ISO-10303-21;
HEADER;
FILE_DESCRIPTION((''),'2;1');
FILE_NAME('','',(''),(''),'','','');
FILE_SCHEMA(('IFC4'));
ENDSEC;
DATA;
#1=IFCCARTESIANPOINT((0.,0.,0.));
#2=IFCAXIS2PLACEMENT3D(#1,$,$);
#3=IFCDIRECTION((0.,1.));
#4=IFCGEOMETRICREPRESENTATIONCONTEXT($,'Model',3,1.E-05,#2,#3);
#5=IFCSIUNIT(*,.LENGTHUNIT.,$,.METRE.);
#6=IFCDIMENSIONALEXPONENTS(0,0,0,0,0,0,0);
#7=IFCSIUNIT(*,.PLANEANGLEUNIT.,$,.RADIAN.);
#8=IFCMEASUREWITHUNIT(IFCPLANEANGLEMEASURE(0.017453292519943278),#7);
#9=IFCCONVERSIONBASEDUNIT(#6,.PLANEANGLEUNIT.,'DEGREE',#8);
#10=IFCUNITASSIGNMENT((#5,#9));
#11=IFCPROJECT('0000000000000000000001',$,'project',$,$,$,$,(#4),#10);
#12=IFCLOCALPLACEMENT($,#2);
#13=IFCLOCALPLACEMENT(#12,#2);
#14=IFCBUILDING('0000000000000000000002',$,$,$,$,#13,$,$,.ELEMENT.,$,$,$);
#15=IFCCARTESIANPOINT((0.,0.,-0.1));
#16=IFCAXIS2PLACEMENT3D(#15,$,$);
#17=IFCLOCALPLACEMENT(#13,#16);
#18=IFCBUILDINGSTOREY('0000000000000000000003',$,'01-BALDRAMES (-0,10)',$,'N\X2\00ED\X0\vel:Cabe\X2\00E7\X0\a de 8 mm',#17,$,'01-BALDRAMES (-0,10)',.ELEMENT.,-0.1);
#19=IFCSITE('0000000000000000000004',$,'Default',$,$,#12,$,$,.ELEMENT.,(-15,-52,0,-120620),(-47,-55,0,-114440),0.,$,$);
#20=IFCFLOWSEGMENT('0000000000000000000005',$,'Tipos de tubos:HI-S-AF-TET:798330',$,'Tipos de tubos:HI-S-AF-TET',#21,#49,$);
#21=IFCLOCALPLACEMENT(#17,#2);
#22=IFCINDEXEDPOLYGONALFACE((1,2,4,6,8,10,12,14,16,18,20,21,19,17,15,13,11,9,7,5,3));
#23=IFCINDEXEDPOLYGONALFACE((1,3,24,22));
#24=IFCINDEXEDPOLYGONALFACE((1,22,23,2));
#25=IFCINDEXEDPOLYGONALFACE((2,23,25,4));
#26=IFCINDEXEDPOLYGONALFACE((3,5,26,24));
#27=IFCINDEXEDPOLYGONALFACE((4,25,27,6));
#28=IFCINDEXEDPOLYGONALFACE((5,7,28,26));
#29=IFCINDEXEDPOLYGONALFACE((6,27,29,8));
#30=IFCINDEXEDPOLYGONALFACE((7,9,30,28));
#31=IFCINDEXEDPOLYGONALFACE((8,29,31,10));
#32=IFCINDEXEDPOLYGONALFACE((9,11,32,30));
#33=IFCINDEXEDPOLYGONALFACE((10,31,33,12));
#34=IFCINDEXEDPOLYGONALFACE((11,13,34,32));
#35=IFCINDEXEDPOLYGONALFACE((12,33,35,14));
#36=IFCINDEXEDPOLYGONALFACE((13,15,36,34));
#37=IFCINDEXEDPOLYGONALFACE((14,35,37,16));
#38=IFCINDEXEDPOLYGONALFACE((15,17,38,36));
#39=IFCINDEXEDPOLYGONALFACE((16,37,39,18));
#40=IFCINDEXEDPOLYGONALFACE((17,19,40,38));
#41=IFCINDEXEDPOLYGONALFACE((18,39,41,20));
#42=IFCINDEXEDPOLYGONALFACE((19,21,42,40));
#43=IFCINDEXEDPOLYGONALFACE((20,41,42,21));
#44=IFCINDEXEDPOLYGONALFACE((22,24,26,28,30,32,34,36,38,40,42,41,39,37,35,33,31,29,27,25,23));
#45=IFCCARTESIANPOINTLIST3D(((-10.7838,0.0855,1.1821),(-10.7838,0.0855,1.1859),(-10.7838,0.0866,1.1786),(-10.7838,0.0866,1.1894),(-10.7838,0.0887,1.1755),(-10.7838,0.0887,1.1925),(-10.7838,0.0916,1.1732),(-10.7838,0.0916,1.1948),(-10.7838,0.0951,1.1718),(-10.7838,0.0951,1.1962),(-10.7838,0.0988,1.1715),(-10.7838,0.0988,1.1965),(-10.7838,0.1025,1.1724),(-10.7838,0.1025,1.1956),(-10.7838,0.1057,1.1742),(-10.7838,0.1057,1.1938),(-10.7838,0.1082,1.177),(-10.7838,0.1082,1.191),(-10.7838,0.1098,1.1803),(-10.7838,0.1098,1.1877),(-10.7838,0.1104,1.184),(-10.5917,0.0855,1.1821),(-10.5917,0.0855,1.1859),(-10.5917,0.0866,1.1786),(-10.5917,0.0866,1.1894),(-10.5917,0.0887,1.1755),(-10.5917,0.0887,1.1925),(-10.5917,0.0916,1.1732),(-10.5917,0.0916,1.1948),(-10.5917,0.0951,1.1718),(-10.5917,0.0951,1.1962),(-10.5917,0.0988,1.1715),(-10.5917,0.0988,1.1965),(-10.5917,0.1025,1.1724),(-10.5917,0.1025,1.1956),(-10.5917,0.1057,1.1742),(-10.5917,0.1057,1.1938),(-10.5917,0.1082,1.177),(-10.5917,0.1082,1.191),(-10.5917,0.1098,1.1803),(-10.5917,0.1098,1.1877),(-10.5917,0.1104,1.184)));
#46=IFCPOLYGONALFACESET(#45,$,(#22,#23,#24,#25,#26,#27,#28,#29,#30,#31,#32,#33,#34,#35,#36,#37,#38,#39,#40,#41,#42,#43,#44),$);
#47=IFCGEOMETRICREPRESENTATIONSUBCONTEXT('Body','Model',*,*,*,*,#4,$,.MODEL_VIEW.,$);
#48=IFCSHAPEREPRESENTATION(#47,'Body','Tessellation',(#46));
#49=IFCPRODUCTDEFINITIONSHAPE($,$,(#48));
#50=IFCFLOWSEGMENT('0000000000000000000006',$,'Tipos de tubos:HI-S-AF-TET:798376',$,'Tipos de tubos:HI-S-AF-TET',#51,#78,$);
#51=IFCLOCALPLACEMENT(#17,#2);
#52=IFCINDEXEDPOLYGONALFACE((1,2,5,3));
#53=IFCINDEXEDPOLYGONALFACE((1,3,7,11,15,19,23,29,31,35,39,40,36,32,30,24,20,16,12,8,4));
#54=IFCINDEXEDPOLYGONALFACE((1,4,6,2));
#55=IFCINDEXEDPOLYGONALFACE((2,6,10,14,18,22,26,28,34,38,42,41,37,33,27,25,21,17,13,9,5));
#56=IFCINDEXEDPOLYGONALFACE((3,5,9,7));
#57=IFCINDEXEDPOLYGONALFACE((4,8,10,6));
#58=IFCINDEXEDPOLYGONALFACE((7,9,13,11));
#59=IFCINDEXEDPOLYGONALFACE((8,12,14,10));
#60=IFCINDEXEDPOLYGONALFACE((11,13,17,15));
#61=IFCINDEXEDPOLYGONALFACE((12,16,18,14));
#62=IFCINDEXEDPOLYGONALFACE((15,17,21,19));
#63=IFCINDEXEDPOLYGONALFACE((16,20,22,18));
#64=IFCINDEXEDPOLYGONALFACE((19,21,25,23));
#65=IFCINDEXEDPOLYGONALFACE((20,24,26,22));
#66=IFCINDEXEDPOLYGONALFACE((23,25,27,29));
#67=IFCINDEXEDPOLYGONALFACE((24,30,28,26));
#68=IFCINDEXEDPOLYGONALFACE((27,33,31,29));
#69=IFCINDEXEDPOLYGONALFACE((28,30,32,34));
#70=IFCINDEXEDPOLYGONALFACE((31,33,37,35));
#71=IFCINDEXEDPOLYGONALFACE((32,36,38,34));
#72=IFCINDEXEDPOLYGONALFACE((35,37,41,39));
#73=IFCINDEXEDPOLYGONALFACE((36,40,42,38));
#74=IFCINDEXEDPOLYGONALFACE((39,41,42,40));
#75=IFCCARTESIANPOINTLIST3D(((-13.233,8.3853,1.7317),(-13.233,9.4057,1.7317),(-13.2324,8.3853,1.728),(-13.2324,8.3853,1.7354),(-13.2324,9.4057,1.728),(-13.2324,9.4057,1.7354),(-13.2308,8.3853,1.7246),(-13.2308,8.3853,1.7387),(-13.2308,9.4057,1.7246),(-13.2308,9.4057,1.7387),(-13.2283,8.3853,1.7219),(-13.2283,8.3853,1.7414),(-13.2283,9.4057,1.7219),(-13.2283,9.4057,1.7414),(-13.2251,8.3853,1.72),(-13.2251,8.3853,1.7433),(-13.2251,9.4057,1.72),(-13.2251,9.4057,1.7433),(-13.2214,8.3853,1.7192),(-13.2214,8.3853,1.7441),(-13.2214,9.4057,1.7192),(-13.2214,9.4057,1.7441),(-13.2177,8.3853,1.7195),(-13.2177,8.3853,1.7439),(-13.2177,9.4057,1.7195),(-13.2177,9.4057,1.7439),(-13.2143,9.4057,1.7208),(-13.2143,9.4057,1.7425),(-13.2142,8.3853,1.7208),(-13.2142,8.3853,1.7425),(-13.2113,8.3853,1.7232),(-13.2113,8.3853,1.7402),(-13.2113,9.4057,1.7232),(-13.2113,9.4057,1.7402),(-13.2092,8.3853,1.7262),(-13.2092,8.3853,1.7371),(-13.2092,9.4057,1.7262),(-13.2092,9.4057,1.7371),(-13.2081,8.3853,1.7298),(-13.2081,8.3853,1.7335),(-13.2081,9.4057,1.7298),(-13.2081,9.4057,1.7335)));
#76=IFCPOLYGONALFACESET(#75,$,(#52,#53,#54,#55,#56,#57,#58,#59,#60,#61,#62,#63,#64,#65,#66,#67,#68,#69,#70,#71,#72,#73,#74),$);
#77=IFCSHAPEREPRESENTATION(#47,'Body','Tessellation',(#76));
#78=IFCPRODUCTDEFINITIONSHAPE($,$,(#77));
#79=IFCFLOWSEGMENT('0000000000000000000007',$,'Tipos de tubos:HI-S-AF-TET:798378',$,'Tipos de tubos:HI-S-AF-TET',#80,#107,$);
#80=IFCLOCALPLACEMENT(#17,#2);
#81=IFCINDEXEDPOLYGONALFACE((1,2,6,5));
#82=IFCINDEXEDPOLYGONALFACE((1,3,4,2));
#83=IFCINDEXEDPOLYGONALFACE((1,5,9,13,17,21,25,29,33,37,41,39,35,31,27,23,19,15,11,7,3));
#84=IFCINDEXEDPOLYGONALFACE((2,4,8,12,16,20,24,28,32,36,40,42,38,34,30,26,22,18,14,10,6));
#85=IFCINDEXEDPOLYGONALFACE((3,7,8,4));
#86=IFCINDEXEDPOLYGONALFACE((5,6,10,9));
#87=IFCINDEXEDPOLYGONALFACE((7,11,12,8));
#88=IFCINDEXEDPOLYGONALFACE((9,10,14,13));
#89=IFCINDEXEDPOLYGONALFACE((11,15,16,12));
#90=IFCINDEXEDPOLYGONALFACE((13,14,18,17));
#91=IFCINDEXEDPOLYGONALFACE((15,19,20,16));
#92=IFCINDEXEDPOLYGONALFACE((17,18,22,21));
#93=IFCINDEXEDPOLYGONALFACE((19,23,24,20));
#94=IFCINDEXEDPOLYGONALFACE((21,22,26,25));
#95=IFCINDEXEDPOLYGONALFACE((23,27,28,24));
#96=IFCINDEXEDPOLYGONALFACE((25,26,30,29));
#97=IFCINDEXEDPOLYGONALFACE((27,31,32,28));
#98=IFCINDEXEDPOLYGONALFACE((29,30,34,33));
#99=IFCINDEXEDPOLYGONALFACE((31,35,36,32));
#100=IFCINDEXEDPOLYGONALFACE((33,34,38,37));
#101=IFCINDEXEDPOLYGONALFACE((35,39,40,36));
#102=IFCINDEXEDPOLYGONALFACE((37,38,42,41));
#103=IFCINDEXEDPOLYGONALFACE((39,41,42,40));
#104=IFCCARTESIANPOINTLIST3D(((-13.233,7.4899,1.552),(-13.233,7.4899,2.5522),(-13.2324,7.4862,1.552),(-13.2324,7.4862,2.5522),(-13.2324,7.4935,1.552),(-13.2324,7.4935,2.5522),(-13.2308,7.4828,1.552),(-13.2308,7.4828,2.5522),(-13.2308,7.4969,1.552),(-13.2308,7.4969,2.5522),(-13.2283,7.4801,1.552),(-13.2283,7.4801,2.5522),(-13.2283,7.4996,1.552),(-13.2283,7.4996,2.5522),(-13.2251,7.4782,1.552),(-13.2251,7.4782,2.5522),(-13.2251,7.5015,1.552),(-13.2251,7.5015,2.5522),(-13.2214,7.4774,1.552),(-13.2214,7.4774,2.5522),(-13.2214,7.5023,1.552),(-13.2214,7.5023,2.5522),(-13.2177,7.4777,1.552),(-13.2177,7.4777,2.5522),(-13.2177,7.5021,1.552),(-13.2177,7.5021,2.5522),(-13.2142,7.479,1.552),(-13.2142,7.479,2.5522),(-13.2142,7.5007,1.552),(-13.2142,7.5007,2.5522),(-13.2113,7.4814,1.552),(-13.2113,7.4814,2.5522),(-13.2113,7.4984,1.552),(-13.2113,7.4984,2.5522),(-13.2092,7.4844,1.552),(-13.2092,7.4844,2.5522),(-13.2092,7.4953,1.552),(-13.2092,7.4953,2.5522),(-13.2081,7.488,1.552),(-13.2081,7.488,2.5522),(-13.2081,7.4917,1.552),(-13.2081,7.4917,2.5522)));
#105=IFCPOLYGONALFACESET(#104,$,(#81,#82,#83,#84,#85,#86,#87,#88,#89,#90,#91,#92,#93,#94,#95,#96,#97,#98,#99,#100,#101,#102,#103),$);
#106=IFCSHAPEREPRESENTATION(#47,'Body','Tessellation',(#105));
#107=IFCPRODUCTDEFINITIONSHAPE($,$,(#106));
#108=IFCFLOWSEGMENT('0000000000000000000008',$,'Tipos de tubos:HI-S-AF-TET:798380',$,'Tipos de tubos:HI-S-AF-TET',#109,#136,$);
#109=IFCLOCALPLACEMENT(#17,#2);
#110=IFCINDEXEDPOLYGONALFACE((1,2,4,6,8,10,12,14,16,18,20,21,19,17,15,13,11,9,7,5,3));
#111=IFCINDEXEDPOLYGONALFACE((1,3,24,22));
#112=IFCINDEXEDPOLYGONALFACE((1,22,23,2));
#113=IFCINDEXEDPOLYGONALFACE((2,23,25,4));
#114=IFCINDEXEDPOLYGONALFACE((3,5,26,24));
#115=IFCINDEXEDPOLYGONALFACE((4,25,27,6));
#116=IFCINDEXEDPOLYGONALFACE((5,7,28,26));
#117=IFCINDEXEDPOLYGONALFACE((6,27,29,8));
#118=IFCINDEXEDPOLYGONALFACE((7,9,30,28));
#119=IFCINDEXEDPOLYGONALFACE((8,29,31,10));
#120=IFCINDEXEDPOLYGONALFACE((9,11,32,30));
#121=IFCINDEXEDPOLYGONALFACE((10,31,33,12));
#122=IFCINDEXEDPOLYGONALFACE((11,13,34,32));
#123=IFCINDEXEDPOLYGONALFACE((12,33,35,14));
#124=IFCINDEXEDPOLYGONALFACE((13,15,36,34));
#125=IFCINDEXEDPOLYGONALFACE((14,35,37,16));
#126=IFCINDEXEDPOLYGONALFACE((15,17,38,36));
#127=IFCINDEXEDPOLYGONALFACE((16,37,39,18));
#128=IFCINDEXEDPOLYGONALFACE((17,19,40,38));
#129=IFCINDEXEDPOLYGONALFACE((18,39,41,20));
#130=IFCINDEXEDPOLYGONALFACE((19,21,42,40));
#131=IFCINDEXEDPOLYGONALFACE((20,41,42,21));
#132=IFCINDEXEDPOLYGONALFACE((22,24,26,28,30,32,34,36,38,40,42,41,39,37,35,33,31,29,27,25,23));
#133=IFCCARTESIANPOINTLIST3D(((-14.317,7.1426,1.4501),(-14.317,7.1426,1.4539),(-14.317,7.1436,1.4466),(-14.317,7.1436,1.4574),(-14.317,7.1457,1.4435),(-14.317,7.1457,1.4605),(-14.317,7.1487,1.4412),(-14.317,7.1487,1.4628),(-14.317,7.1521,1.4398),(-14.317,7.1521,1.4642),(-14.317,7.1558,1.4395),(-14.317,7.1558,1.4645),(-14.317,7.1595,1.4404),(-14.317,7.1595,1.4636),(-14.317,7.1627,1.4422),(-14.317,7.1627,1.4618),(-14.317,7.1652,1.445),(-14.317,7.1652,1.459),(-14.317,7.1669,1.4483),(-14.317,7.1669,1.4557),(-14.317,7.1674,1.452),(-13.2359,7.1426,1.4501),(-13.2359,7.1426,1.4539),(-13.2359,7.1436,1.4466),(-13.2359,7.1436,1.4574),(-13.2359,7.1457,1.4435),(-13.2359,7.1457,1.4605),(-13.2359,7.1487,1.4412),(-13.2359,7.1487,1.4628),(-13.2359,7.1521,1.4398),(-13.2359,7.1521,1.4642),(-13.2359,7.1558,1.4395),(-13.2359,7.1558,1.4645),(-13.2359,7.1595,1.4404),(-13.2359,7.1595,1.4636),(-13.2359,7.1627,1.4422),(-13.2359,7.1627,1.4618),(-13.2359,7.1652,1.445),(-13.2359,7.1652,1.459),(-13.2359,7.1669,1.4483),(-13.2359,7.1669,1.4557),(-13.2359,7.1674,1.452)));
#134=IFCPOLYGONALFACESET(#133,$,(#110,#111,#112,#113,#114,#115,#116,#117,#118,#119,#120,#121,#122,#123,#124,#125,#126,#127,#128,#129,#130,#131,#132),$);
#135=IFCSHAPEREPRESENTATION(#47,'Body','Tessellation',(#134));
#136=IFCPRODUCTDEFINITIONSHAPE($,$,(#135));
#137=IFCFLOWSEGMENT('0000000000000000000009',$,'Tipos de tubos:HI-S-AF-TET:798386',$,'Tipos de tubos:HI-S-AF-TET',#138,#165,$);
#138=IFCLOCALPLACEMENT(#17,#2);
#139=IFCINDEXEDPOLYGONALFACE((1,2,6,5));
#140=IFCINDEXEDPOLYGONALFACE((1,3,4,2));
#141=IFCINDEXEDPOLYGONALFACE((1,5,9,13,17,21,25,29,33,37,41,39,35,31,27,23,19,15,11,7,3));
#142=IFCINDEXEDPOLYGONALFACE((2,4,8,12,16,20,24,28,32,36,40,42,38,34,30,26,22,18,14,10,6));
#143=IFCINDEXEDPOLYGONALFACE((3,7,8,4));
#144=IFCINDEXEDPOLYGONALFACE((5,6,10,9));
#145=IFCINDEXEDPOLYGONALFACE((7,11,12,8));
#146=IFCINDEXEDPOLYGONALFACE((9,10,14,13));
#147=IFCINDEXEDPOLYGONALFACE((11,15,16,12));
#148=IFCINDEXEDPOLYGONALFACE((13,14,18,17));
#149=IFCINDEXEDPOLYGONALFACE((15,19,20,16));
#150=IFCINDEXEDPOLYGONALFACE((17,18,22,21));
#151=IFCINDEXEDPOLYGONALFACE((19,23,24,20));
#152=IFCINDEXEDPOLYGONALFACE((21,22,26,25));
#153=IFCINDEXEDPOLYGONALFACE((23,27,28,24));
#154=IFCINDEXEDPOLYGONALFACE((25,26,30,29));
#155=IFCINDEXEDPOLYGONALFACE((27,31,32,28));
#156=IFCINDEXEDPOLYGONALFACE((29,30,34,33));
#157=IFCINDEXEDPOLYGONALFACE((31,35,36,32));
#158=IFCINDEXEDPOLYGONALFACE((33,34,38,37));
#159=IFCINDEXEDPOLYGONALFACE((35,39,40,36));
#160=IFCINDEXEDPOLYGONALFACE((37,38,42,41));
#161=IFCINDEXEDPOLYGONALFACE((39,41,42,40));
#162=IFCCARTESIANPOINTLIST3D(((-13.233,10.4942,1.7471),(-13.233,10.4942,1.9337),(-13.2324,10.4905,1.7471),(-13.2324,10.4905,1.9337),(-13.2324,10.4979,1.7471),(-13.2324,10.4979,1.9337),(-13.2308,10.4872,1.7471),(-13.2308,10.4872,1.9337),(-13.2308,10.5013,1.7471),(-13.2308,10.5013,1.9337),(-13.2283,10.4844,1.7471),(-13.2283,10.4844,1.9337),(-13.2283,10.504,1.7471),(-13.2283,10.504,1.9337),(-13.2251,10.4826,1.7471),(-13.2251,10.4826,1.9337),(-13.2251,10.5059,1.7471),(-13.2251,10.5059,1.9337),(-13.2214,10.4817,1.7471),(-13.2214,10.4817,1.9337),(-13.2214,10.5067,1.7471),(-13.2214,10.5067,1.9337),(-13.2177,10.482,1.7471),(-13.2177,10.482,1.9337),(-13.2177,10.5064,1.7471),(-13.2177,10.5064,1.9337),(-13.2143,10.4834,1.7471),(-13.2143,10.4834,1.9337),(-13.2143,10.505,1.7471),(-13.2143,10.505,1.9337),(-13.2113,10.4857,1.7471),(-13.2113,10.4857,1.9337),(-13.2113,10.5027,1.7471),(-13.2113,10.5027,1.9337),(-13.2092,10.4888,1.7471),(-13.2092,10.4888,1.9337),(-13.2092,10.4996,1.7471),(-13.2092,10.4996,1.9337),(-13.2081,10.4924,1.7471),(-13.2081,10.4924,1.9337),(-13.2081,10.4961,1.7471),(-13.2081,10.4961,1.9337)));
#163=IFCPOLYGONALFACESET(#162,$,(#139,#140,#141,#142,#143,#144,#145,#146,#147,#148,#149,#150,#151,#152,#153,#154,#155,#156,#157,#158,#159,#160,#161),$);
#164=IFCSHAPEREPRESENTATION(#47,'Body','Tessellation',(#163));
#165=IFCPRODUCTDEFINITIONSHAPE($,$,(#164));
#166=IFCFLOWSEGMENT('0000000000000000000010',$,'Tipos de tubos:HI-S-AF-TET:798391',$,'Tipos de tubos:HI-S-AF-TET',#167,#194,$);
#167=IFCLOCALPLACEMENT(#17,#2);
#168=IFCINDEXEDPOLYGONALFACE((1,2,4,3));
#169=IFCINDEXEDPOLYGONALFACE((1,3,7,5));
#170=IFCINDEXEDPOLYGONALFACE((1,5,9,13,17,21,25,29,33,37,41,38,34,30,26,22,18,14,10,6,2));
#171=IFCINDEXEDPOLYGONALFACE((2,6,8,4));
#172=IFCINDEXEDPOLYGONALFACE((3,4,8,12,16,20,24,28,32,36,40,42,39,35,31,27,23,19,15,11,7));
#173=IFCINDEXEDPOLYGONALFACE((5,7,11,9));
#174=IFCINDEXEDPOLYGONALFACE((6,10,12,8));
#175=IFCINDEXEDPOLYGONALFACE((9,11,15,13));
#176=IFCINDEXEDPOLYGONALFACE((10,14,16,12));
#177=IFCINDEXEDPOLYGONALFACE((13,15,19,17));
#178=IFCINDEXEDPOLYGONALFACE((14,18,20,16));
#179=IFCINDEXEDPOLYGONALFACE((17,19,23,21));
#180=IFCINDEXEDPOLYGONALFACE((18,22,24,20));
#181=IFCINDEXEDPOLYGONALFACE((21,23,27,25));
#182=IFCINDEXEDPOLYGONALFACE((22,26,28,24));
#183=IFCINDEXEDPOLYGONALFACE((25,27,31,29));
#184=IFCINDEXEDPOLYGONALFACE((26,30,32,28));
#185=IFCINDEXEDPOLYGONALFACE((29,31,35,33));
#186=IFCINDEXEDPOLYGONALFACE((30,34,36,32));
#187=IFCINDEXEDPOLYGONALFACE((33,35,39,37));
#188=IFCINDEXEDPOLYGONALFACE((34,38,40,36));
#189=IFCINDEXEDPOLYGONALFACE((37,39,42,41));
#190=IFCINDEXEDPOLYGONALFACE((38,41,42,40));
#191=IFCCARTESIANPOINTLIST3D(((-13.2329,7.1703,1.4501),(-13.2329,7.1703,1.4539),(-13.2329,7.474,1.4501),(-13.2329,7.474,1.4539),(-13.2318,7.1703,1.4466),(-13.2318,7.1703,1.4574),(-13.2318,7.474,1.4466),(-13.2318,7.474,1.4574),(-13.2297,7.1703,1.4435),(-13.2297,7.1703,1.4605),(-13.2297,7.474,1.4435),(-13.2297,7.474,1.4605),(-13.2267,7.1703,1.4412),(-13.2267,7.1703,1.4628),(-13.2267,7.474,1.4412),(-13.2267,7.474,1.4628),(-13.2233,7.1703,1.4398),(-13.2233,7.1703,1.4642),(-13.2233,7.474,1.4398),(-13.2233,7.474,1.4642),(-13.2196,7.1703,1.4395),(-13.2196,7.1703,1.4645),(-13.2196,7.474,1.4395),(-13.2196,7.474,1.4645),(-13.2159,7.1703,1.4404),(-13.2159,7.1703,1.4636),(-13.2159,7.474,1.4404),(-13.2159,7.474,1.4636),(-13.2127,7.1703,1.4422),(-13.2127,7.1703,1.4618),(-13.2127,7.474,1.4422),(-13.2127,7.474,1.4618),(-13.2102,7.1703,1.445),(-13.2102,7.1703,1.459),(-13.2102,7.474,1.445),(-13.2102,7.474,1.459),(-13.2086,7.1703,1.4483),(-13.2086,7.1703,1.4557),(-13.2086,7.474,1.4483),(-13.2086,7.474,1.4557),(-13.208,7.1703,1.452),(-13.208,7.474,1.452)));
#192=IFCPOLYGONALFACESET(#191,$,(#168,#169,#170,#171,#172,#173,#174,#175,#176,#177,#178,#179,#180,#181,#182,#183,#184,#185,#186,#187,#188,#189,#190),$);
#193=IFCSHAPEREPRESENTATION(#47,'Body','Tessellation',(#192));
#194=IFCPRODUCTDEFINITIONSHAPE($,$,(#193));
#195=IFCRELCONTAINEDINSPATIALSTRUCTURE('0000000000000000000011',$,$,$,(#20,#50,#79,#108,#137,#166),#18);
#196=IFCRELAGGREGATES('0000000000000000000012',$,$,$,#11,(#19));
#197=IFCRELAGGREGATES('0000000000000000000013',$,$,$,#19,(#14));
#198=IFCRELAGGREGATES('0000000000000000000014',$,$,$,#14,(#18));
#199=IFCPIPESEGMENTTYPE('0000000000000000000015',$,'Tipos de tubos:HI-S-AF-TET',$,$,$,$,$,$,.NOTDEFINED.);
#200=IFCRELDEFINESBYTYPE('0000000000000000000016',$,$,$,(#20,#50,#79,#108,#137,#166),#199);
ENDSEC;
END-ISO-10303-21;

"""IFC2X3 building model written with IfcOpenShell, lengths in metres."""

from ifc_helpers import new_model, entity, si_unit, converted_unit, direction, frame, frame_2d, origin, origin_2d_with_axis, place, context, subcontext, project, spatial, circle, extrude, type_object, element, save


model = new_model("IFC2X3")

# Units and contexts
model_context = context("Model", 3, precision=1e-05, world=origin(), true_north=direction((0.0, 1.0)))
body_context = subcontext(model_context, "Body", "Model", "MODEL_VIEW")
ifc_project = project(units=[si_unit("LENGTHUNIT", "METRE"), converted_unit("PLANEANGLEUNIT", "DEGREE", entity("IfcPlaneAngleMeasure", 0.017453292519943278), si_unit("PLANEANGLEUNIT", "RADIAN"), dimensions=[0, 0, 0, 0, 0, 0, 0])], contexts=[model_context])

# Site, building, storey
site_placement = place(None, origin())
site = spatial("IfcSite", under=ifc_project, at=site_placement, Name="Default", CompositionType="ELEMENT", RefLatitude=(-15, -52, 0, -120620), RefLongitude=(-47, -55, 0, -114440), RefElevation=0.0)
building_placement = place(site_placement, origin())
building = spatial("IfcBuilding", under=site, at=building_placement, CompositionType="ELEMENT")
storey_placement = place(building_placement, frame((0.0, 0.0, -0.1)))
storey = spatial("IfcBuildingStorey", under=building, at=storey_placement, Name="01-BALDRAMES (-0,10)", ObjectType="Nível:Cabeça de 8 mm", LongName="01-BALDRAMES (-0,10)", CompositionType="ELEMENT", Elevation=-0.1)

# Flow segments
pipe_segment_type_1 = type_object("IfcPipeSegmentType", Name="Tipos de tubos:HI-S-AF-TET", PredefinedType="NOTDEFINED")
flow_segment_1_placement = place(storey_placement, origin())
element("IfcFlowSegment", 1, at=flow_segment_1_placement, inside=storey, type_object=pipe_segment_type_1, Name="Tipos de tubos:HI-S-AF-TET:798330", ObjectType="Tipos de tubos:HI-S-AF-TET", context=body_context, shape_type="SweptSolid", body=[
    extrude(circle(Radius=0.0125, at=frame_2d((0.0, 0.0), x_axis=(1.0, 0.0))), frame((-10.7838, 0.0979, 1.184), z_axis=(1.0, 0.000003, 0.0), x_axis=(-0.000003, 1.0, 0.0)), (0.0, 0.0, 1.0), 0.1921),
])
flow_segment_2_placement = place(storey_placement, origin())
element("IfcFlowSegment", 2, at=flow_segment_2_placement, inside=storey, type_object=pipe_segment_type_1, Name="Tipos de tubos:HI-S-AF-TET:798376", ObjectType="Tipos de tubos:HI-S-AF-TET", context=body_context, shape_type="SweptSolid", body=[
    extrude(circle(Radius=0.0125, at=origin_2d_with_axis()), frame((-13.2205, 8.3853, 1.7317), z_axis=(-0.000006, 1.0, 0.0), x_axis=(-1.0, -0.000006, 0.0)), (0.0, 0.0, 1.0), 1.0205),
])
flow_segment_3_placement = place(storey_placement, origin())
element("IfcFlowSegment", 3, at=flow_segment_3_placement, inside=storey, type_object=pipe_segment_type_1, Name="Tipos de tubos:HI-S-AF-TET:798378", ObjectType="Tipos de tubos:HI-S-AF-TET", context=body_context, shape_type="SweptSolid", body=[
    extrude(circle(Radius=0.0125, at=frame_2d((0.0, 0.0), x_axis=(1.0, 0.0))), frame((-13.2205, 7.4899, 1.552), z_axis=(0.0, 0.0, 1.0), x_axis=(-1.0, 0.0, 0.0)), (0.0, 0.0, 1.0), 1.0002),
])
flow_segment_4_placement = place(storey_placement, origin())
element("IfcFlowSegment", 4, at=flow_segment_4_placement, inside=storey, type_object=pipe_segment_type_1, Name="Tipos de tubos:HI-S-AF-TET:798380", ObjectType="Tipos de tubos:HI-S-AF-TET", context=body_context, shape_type="SweptSolid", body=[
    extrude(circle(Radius=0.0125, at=origin_2d_with_axis()), frame((-14.317, 7.1549, 1.452), z_axis=(1.0, 0.0, 0.0), x_axis=(0.0, 1.0, 0.0)), (0.0, 0.0, 1.0), 1.0811),
])
flow_segment_5_placement = place(storey_placement, origin())
element("IfcFlowSegment", 5, at=flow_segment_5_placement, inside=storey, type_object=pipe_segment_type_1, Name="Tipos de tubos:HI-S-AF-TET:798386", ObjectType="Tipos de tubos:HI-S-AF-TET", context=body_context, shape_type="SweptSolid", body=[
    extrude(circle(Radius=0.0125, at=origin_2d_with_axis()), frame((-13.2205, 10.4942, 1.7471), z_axis=(0.0, 0.0, 1.0), x_axis=(-1.0, 0.0, 0.0)), (0.0, 0.0, 1.0), 0.1866),
])
flow_segment_6_placement = place(storey_placement, origin())
element("IfcFlowSegment", 6, at=flow_segment_6_placement, inside=storey, type_object=pipe_segment_type_1, Name="Tipos de tubos:HI-S-AF-TET:798391", ObjectType="Tipos de tubos:HI-S-AF-TET", context=body_context, shape_type="SweptSolid", body=[
    extrude(circle(Radius=0.0125, at=origin_2d_with_axis()), frame((-13.2205, 7.1703, 1.452), z_axis=(0.000005, 1.0, 0.0), x_axis=(1.0, -0.000005, 0.0)), (0.0, 0.0, 1.0), 0.3037),
])

save(model, "model.ifc")
